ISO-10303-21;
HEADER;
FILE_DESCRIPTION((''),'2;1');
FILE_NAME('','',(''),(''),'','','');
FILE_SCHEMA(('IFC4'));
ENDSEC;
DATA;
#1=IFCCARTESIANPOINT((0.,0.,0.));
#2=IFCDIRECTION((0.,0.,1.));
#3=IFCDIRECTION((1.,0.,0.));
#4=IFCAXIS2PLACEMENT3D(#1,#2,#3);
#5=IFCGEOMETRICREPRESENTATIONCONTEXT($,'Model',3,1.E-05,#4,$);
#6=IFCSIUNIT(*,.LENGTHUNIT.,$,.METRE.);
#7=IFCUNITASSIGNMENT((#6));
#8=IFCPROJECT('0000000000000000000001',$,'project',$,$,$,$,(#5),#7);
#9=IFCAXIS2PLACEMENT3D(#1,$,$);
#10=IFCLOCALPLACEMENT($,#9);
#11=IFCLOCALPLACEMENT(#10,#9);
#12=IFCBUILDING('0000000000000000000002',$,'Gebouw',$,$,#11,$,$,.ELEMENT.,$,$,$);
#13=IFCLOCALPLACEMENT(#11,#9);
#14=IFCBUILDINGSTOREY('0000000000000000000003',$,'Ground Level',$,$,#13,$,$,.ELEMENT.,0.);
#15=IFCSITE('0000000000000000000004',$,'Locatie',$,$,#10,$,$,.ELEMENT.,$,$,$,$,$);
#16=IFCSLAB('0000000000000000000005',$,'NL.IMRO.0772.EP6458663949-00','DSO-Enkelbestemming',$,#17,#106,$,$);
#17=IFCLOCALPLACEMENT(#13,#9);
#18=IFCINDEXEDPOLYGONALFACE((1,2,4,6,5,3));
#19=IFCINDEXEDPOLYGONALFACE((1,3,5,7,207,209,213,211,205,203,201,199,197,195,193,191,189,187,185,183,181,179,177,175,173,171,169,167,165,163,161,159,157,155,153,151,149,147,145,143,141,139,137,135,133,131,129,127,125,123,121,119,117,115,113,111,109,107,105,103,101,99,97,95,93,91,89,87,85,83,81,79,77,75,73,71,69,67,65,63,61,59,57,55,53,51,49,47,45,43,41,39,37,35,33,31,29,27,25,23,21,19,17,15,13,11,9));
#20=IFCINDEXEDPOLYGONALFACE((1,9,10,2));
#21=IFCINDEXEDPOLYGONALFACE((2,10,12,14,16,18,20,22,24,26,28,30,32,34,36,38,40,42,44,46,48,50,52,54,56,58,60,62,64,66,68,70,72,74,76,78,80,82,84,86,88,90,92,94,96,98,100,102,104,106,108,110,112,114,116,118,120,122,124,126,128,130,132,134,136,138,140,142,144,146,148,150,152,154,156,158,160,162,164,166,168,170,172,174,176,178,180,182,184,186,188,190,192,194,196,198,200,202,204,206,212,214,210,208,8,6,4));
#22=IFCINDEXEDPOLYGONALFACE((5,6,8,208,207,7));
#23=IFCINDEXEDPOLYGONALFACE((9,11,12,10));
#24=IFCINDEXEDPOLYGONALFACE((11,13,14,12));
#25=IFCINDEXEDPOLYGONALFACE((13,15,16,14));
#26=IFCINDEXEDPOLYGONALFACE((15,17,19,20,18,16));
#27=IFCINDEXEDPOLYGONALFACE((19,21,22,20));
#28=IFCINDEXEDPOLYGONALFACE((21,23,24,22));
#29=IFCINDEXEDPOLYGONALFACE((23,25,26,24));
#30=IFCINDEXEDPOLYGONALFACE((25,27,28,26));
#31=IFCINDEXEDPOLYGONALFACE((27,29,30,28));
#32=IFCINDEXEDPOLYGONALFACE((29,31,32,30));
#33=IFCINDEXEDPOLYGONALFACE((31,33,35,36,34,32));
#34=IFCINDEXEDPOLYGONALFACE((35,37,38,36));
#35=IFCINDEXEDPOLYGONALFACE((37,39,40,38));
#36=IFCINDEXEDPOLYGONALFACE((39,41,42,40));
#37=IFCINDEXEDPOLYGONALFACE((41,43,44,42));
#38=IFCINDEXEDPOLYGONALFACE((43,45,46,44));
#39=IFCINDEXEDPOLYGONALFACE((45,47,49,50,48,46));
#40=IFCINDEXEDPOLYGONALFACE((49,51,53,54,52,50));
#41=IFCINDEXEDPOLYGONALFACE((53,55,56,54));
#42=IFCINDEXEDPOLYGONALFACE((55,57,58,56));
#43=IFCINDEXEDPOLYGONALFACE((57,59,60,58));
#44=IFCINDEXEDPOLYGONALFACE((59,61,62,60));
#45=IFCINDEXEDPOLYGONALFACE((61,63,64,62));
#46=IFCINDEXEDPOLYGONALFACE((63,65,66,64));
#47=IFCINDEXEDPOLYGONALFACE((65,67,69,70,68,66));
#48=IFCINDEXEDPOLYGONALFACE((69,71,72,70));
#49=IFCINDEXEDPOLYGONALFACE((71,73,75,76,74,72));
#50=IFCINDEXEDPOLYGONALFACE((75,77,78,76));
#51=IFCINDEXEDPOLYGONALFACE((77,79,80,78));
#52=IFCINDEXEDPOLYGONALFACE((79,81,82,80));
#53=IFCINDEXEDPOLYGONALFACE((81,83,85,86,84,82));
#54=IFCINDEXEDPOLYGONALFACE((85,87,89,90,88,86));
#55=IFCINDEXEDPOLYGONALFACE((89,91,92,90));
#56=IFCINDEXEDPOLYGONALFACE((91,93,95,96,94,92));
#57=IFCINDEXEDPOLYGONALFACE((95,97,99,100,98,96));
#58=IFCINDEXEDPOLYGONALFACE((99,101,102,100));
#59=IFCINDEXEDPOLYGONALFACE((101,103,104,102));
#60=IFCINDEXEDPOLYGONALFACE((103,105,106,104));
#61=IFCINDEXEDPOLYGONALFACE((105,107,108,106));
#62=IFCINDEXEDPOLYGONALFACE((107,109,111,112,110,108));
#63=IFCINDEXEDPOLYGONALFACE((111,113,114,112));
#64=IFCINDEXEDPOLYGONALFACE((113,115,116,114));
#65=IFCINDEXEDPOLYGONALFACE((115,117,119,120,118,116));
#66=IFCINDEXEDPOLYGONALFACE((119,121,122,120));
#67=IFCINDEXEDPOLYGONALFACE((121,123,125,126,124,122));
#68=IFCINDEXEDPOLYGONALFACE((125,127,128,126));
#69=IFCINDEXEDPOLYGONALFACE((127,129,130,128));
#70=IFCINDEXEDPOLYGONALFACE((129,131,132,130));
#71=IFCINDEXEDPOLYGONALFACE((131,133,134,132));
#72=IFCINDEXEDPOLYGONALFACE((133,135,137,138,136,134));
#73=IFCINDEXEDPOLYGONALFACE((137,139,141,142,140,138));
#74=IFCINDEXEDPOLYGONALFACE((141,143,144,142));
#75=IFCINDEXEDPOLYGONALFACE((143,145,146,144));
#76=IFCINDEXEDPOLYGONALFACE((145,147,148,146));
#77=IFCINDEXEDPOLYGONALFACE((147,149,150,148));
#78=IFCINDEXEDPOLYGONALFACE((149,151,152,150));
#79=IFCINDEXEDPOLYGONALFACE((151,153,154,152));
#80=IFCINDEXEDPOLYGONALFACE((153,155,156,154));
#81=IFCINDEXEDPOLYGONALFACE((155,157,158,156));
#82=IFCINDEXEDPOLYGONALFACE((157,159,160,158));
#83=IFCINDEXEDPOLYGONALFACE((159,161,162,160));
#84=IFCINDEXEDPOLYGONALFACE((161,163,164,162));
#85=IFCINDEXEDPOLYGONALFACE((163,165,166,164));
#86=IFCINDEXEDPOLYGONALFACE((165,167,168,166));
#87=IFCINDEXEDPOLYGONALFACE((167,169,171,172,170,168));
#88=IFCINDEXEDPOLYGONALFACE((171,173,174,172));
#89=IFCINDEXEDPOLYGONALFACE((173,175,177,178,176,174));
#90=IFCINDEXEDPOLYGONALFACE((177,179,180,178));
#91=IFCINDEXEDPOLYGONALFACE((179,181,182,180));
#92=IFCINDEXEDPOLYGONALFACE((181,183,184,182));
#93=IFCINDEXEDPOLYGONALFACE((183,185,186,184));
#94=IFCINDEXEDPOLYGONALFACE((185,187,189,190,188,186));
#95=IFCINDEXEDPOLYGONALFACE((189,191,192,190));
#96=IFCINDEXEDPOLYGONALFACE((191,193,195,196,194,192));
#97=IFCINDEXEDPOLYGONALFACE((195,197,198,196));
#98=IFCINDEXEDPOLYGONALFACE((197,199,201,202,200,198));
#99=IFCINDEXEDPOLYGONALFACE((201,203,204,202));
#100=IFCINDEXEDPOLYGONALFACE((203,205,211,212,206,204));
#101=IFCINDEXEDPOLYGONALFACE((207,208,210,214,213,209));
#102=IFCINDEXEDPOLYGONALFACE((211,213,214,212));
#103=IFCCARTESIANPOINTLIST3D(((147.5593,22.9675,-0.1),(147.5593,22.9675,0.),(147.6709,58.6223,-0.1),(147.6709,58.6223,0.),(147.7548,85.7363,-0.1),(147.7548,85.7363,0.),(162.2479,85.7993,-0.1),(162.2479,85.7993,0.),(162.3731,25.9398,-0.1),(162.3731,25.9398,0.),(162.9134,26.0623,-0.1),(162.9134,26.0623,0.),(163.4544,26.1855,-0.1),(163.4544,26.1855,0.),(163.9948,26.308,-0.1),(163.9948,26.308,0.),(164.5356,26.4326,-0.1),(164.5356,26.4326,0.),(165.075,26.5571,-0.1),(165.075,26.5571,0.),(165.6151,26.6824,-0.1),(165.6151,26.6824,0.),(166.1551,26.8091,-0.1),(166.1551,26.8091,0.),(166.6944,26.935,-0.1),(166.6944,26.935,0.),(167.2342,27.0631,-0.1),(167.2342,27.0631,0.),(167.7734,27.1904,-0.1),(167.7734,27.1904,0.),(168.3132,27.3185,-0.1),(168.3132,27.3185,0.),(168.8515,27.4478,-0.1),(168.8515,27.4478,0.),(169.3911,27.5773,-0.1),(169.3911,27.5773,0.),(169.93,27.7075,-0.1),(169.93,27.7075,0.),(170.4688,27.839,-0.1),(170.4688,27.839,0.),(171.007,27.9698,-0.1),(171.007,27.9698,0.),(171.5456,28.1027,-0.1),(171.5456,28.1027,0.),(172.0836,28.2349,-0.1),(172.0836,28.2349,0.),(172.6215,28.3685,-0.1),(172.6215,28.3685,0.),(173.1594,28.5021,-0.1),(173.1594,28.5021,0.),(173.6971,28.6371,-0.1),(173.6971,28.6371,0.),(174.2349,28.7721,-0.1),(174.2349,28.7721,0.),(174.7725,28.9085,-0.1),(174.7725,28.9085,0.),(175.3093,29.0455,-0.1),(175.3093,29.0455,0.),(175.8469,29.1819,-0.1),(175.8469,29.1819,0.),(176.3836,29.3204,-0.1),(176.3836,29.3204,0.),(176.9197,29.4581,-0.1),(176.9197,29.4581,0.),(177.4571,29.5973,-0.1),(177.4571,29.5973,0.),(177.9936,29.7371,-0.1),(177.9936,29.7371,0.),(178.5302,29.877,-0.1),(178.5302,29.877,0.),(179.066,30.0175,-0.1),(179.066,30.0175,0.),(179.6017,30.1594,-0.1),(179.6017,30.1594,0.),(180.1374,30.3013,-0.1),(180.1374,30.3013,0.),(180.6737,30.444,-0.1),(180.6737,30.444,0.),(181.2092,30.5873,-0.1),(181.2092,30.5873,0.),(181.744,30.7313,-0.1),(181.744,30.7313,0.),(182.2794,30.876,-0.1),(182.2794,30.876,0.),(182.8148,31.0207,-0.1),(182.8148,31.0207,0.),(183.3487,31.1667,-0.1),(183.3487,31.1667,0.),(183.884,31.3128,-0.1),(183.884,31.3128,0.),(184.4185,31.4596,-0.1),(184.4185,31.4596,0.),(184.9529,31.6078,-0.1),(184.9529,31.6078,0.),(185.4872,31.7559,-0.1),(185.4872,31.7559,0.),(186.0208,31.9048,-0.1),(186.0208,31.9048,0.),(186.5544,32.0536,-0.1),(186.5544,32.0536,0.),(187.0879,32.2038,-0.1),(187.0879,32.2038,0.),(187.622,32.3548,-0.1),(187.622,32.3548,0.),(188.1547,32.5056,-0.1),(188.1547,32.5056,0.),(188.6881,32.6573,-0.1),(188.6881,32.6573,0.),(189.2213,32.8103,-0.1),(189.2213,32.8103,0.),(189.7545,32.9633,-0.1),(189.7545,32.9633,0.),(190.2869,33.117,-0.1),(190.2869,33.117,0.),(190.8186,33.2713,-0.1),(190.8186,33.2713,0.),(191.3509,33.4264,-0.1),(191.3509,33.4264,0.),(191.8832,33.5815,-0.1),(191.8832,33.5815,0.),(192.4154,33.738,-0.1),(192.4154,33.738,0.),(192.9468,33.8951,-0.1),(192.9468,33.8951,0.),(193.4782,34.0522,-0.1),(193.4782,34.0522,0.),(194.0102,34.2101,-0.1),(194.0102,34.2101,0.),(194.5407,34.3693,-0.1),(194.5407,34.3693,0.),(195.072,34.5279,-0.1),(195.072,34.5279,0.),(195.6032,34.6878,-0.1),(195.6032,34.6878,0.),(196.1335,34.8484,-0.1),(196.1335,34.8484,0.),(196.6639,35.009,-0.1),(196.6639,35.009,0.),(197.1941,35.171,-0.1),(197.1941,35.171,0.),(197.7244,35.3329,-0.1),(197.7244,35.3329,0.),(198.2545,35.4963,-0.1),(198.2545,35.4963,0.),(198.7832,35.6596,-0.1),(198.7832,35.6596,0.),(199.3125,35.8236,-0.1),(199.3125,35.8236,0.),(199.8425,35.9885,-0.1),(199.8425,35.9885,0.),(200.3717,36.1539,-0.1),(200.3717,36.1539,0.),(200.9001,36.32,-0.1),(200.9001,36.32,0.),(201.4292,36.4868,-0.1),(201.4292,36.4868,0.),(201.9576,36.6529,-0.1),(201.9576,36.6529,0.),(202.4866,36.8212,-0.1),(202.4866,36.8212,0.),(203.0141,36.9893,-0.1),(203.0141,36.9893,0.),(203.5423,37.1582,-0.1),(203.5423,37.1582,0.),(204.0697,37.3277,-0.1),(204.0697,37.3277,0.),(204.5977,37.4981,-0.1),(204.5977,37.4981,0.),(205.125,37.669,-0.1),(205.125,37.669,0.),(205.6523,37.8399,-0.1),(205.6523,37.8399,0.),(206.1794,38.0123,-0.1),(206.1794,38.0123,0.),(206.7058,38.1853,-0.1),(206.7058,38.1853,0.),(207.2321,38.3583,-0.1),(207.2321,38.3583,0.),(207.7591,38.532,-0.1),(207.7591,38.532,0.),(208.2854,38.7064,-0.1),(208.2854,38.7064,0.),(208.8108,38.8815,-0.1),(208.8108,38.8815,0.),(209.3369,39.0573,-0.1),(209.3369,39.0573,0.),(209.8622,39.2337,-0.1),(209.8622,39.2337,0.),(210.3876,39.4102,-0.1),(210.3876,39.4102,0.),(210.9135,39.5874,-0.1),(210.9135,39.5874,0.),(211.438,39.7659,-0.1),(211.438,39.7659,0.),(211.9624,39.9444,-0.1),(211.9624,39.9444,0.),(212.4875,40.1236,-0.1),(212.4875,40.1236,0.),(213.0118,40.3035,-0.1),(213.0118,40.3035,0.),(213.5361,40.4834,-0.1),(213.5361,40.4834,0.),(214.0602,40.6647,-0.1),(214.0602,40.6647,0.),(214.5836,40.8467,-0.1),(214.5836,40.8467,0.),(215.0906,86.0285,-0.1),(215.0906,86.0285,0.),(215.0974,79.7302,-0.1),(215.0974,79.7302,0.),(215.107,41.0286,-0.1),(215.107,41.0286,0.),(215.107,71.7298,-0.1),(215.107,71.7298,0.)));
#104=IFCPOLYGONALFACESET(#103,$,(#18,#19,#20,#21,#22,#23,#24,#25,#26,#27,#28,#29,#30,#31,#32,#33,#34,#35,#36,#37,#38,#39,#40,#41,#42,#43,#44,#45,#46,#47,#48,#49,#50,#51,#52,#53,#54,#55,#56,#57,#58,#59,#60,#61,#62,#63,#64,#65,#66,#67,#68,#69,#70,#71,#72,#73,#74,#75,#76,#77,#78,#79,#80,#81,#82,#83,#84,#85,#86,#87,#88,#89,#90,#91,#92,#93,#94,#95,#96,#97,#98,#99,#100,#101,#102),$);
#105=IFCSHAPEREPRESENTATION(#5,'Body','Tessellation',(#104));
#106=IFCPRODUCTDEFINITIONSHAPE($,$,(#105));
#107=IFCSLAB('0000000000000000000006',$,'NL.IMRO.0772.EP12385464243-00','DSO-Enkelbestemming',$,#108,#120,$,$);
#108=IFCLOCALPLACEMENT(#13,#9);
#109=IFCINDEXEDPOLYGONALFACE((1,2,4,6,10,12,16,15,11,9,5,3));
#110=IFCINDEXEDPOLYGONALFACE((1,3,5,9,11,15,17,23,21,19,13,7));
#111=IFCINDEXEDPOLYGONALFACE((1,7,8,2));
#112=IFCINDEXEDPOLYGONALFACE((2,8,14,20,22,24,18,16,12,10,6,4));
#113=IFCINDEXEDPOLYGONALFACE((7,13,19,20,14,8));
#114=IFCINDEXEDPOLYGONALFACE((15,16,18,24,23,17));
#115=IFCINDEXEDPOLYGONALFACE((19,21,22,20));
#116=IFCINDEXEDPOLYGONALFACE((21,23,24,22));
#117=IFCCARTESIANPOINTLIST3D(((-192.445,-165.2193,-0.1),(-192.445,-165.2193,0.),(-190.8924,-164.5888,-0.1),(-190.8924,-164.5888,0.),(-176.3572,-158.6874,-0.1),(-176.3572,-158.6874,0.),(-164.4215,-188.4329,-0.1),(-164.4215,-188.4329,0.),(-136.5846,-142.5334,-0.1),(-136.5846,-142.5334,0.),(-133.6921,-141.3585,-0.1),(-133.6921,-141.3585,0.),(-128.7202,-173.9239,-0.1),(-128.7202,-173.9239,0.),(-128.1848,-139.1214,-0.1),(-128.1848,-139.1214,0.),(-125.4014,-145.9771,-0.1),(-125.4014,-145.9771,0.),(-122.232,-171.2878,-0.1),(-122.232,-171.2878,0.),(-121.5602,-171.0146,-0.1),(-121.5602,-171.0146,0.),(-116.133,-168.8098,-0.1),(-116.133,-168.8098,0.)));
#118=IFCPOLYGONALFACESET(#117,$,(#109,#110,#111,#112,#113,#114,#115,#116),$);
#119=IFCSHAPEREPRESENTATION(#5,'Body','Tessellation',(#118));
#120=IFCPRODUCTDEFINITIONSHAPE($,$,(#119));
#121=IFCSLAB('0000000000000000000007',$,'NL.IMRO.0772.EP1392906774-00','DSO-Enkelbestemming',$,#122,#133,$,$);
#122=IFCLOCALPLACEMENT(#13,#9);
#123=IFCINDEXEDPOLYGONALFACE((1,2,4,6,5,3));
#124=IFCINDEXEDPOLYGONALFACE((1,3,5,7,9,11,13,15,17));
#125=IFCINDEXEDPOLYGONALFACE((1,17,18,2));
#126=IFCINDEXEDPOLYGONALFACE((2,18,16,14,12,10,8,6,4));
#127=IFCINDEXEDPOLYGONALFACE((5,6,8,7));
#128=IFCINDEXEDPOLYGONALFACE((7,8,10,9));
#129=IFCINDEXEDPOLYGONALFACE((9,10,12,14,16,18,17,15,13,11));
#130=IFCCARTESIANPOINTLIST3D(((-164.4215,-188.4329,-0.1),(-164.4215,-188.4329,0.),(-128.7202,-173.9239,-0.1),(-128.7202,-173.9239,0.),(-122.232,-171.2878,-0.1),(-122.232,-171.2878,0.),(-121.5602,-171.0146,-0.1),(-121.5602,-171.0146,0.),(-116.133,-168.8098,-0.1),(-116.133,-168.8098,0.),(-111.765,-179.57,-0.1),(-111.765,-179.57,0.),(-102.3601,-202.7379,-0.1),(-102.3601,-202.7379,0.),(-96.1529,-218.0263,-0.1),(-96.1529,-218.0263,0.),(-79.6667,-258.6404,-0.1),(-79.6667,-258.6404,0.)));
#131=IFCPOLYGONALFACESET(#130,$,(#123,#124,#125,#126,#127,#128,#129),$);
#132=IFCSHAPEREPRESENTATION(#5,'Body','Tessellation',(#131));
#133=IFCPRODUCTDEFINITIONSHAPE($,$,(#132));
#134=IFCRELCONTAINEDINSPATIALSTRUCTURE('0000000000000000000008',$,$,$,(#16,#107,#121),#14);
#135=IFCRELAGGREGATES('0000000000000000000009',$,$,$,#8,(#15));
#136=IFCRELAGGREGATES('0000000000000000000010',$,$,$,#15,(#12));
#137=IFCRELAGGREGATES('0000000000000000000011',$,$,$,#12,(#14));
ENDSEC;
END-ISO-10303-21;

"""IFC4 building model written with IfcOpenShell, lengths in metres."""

from ifc_helpers import new_model, si_unit, frame, origin, origin_with_axes, place, context, project, spatial, polyline, outline, extrude, element, save


model = new_model("IFC4")

# Units and contexts
model_context = context("Model", 3, precision=1e-05, world=origin_with_axes())
ifc_project = project(units=[si_unit("LENGTHUNIT", "METRE")], contexts=[model_context])

# Site, building, storey
site_placement = place(None, origin())
site = spatial("IfcSite", under=ifc_project, at=site_placement, Name="Locatie", CompositionType="ELEMENT")
building_placement = place(site_placement, origin())
building = spatial("IfcBuilding", under=site, at=building_placement, Name="Gebouw", CompositionType="ELEMENT")
storey_placement = place(building_placement, origin())
storey = spatial("IfcBuildingStorey", under=building, at=storey_placement, Name="Ground Level", CompositionType="ELEMENT", Elevation=0.0)

# Slabs
slab_1_placement = place(storey_placement, origin())
element("IfcSlab", 1, at=slab_1_placement, inside=storey, Name="NL.IMRO.0772.EP6458663949-00", Description="DSO-Enkelbestemming", context=model_context, shape_type="SweptSolid", body=[
    extrude(outline(polyline([(147.5593, 22.9675), (147.6709, 58.6223), (147.7548, 85.7363), (162.2479, 85.7993), (215.0906, 86.0285), (215.0974, 79.7302), (215.107, 71.7298), (215.107, 41.0286), (214.5836, 40.8467), (214.0602, 40.6647), (213.5361, 40.4834), (213.0118, 40.3035), (212.4875, 40.1236), (211.9624, 39.9444), (211.438, 39.7659), (210.9135, 39.5874), (210.3876, 39.4102), (209.8622, 39.2337), (209.3369, 39.0573), (208.8108, 38.8815), (208.2854, 38.7064), (207.7591, 38.532), (207.2321, 38.3583), (206.7058, 38.1853), (206.1794, 38.0123), (205.6523, 37.8399), (205.125, 37.669), (204.5977, 37.4981), (204.0697, 37.3277), (203.5423, 37.1582), (203.0141, 36.9893), (202.4866, 36.8212), (201.9576, 36.6529), (201.4292, 36.4868), (200.9001, 36.32), (200.3717, 36.1539), (199.8425, 35.9885), (199.3125, 35.8236), (198.7832, 35.6596), (198.2545, 35.4963), (197.7244, 35.3329), (197.1941, 35.171), (196.6639, 35.009), (196.1335, 34.8484), (195.6032, 34.6878), (195.072, 34.5279), (194.5407, 34.3693), (194.0102, 34.2101), (193.4782, 34.0522), (192.9468, 33.8951), (192.4154, 33.738), (191.8832, 33.5815), (191.3509, 33.4264), (190.8186, 33.2713), (190.2869, 33.117), (189.7545, 32.9633), (189.2213, 32.8103), (188.6881, 32.6573), (188.1547, 32.5056), (187.622, 32.3548), (187.0879, 32.2038), (186.5544, 32.0536), (186.0208, 31.9048), (185.4872, 31.7559), (184.9529, 31.6078), (184.4185, 31.4596), (183.884, 31.3128), (183.3487, 31.1667), (182.8148, 31.0207), (182.2794, 30.876), (181.744, 30.7313), (181.2092, 30.5873), (180.6737, 30.444), (180.1374, 30.3013), (179.6017, 30.1594), (179.066, 30.0175), (178.5302, 29.877), (177.9936, 29.7371), (177.4571, 29.5973), (176.9197, 29.4581), (176.3836, 29.3204), (175.8469, 29.1819), (175.3093, 29.0455), (174.7725, 28.9085), (174.2349, 28.7721), (173.6971, 28.6371), (173.1594, 28.5021), (172.6215, 28.3685), (172.0836, 28.2349), (171.5456, 28.1027), (171.007, 27.9698), (170.4688, 27.839), (169.93, 27.7075), (169.3911, 27.5773), (168.8515, 27.4478), (168.3132, 27.3185), (167.7734, 27.1904), (167.2342, 27.0631), (166.6944, 26.935), (166.1551, 26.8091), (165.6151, 26.6824), (165.075, 26.5571), (164.5356, 26.4326), (163.9948, 26.308), (163.4544, 26.1855), (162.9134, 26.0623), (162.3731, 25.9398), (147.5593, 22.9675)])), frame((0.0, 0.0, -0.1), z_axis=(0.0, 0.0, 1.0), x_axis=(1.0, 0.0, 0.0)), (0.0, 0.0, 1.0), 0.1),
])
slab_2_placement = place(storey_placement, origin())
element("IfcSlab", 2, at=slab_2_placement, inside=storey, Name="NL.IMRO.0772.EP12385464243-00", Description="DSO-Enkelbestemming", context=model_context, shape_type="SweptSolid", body=[
    extrude(outline(polyline([(-190.8924, -164.5888), (-176.3572, -158.6874), (-136.5846, -142.5334), (-133.6921, -141.3585), (-128.1848, -139.1214), (-125.4014, -145.9771), (-116.133, -168.8098), (-121.5602, -171.0146), (-122.232, -171.2878), (-128.7202, -173.9239), (-164.4215, -188.4329), (-192.445, -165.2193), (-190.8924, -164.5888)])), frame((0.0, 0.0, -0.1), z_axis=(0.0, 0.0, 1.0), x_axis=(1.0, 0.0, 0.0)), (0.0, 0.0, 1.0), 0.1),
])
slab_3_placement = place(storey_placement, origin())
element("IfcSlab", 3, at=slab_3_placement, inside=storey, Name="NL.IMRO.0772.EP1392906774-00", Description="DSO-Enkelbestemming", context=model_context, shape_type="SweptSolid", body=[
    extrude(outline(polyline([(-128.7202, -173.9239), (-122.232, -171.2878), (-121.5602, -171.0146), (-116.133, -168.8098), (-111.765, -179.57), (-102.3601, -202.7379), (-96.1529, -218.0263), (-79.6667, -258.6404), (-164.4215, -188.4329), (-128.7202, -173.9239)])), frame((0.0, 0.0, -0.1), z_axis=(0.0, 0.0, 1.0), x_axis=(1.0, 0.0, 0.0)), (0.0, 0.0, 1.0), 0.1),
])

save(model, "model.ifc")
